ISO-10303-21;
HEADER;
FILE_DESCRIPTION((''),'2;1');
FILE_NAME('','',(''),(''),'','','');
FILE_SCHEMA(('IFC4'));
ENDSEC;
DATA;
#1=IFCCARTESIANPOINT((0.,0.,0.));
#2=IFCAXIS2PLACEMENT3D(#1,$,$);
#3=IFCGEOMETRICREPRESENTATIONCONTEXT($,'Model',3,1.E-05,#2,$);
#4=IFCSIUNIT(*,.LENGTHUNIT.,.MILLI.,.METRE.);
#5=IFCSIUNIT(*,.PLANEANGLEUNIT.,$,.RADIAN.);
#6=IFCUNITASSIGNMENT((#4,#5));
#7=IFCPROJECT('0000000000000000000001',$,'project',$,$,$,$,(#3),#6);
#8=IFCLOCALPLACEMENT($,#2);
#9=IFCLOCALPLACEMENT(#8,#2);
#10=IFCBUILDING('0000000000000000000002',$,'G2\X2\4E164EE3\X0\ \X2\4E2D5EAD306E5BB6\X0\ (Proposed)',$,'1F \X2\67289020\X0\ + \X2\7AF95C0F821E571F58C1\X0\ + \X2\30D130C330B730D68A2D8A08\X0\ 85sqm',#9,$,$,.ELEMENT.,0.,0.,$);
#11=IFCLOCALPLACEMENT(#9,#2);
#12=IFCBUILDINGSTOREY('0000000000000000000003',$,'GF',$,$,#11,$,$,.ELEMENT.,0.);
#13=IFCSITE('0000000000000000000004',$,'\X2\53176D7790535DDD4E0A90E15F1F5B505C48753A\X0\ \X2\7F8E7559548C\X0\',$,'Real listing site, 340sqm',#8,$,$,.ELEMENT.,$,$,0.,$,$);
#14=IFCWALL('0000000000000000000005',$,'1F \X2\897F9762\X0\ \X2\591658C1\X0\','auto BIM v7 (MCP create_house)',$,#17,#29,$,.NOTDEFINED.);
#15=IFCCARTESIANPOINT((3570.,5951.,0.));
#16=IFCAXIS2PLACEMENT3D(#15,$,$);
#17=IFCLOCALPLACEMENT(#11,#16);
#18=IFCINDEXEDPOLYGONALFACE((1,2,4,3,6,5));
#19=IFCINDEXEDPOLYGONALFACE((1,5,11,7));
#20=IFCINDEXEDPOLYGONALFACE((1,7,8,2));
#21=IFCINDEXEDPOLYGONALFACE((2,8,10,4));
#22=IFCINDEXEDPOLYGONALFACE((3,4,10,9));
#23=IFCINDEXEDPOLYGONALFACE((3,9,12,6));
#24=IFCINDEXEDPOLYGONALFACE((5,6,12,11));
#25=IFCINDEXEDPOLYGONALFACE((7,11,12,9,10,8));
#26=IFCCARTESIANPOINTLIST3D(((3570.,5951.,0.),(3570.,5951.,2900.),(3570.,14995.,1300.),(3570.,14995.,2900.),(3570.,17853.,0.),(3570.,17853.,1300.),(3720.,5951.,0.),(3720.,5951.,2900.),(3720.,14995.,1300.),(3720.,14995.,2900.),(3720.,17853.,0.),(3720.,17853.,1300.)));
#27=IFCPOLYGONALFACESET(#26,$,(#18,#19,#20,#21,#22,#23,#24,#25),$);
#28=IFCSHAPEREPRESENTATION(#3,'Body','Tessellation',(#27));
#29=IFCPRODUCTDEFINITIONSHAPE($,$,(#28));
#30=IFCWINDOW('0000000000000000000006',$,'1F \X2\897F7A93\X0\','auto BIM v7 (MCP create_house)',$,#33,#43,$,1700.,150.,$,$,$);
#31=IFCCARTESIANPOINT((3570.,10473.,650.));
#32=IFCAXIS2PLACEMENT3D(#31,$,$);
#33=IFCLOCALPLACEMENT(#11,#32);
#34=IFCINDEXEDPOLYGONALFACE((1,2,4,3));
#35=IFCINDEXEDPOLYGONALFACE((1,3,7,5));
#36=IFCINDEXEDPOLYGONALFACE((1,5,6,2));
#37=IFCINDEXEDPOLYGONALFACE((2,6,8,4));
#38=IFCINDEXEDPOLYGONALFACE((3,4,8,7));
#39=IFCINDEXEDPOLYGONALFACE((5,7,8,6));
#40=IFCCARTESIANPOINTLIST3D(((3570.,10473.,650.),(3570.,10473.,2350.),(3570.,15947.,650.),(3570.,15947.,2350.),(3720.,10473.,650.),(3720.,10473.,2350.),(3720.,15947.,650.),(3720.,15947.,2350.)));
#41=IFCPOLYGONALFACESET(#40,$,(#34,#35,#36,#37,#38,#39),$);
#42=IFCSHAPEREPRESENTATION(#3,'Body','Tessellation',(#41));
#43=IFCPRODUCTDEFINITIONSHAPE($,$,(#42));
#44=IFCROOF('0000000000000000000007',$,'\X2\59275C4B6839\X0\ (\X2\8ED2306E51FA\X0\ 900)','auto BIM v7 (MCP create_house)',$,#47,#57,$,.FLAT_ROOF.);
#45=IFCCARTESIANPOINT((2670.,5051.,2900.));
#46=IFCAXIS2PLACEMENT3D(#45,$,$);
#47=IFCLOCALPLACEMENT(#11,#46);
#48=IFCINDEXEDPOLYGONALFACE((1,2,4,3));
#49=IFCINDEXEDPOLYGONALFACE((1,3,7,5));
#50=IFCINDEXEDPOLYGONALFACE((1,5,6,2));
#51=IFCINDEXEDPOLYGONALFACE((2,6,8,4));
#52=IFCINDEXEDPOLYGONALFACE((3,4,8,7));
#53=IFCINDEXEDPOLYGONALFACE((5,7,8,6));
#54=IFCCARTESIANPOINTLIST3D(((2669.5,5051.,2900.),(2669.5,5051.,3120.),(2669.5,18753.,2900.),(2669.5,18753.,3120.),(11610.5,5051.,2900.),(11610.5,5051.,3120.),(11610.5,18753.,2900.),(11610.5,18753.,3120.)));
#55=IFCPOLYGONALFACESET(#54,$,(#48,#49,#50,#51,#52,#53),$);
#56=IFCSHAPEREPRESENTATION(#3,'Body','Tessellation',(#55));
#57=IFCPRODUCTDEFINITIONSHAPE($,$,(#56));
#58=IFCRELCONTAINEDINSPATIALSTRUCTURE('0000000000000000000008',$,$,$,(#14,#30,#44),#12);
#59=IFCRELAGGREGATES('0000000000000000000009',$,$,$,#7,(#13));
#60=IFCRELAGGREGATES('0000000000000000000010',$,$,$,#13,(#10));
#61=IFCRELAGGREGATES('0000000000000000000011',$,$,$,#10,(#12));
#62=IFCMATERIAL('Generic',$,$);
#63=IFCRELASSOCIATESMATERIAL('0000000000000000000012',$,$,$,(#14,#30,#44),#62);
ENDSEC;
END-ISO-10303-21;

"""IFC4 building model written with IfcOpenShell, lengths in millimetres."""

from ifc_helpers import new_model, si_unit, frame, frame_2d, origin, place, context, project, spatial, rectangle, extrude, material, element, fill, save


model = new_model("IFC4")

# Units and contexts
model_context = context("Model", 3, precision=1e-05, world=origin())
ifc_project = project(units=[si_unit("LENGTHUNIT", "METRE", prefix="MILLI"), si_unit("PLANEANGLEUNIT", "RADIAN")], contexts=[model_context])

# Site, building, storey
site_placement = place(None, origin())
site = spatial("IfcSite", under=ifc_project, at=site_placement, Name="北海道川上郡弟子屈町 美留和", ObjectType="Real listing site, 340sqm", CompositionType="ELEMENT", RefElevation=0.0)
building_placement = place(site_placement, origin())
building = spatial("IfcBuilding", under=site, at=building_placement, Name="G2世代 中庭の家 (Proposed)", ObjectType="1F 木造 + 竹小舞土壁 + パッシブ設計 85sqm", CompositionType="ELEMENT", ElevationOfRefHeight=0.0, ElevationOfTerrain=0.0)
storey_placement = place(building_placement, origin())
storey = spatial("IfcBuildingStorey", under=building, at=storey_placement, Name="GF", CompositionType="ELEMENT", Elevation=0.0)

# Shared definitions
ifc_material = material(Name="Generic")

# Wall, opening, window
wall_1_placement = place(storey_placement, frame((3570.0, 5951.0, 0.0)))
wall_1 = element("IfcWall", 1, at=wall_1_placement, inside=storey, material=ifc_material, Name="1F 西面 外壁", Description="auto BIM v7 (MCP create_house)", PredefinedType="NOTDEFINED", context=model_context, shape_type="SweptSolid", body=[
    extrude(rectangle(XDim=150.0, YDim=11902.0, at=frame_2d((75.0, 5951.0))), frame((3570.0, 5951.0, 0.0)), (0.0, 0.0, 1.0), 2900.0),
])
opening_1_placement = place(storey_placement, frame((3570.0, 10473.0, 650.0)))
opening_1 = element("IfcOpeningElement", 2, at=opening_1_placement, cuts=wall_1, PredefinedType="NOTDEFINED", context=model_context, shape_type="SweptSolid", body=[
    extrude(rectangle(XDim=150.0, YDim=5474.0, at=frame_2d((75.0, 2737.0))), frame((3570.0, 10473.0, 650.0)), (0.0, 0.0, 1.0), 1700.0),
])
window_1_placement = place(storey_placement, frame((3570.0, 10473.0, 650.0)))
window_1 = element("IfcWindow", 3, at=window_1_placement, inside=storey, material=ifc_material, Name="1F 西窓", Description="auto BIM v7 (MCP create_house)", OverallHeight=1700.0, OverallWidth=150.0, context=model_context, shape_type="SweptSolid", body=[
    extrude(rectangle(XDim=150.0, YDim=5474.0, at=frame_2d((75.0, 2737.0))), frame((3570.0, 10473.0, 650.0)), (0.0, 0.0, 1.0), 1700.0),
])
fill(opening_1, window_1)

# Roof
roof_placement = place(storey_placement, frame((2670.0, 5051.0, 2900.0)))
element("IfcRoof", 4, at=roof_placement, inside=storey, material=ifc_material, Name="大屋根 (軒の出 900)", Description="auto BIM v7 (MCP create_house)", PredefinedType="FLAT_ROOF", context=model_context, shape_type="SweptSolid", body=[
    extrude(rectangle(XDim=8941.0, YDim=13702.0, at=frame_2d((4470.0, 6851.0))), frame((2670.0, 5051.0, 2900.0)), (0.0, 0.0, 1.0), 220.0),
])

save(model, "model.ifc")
